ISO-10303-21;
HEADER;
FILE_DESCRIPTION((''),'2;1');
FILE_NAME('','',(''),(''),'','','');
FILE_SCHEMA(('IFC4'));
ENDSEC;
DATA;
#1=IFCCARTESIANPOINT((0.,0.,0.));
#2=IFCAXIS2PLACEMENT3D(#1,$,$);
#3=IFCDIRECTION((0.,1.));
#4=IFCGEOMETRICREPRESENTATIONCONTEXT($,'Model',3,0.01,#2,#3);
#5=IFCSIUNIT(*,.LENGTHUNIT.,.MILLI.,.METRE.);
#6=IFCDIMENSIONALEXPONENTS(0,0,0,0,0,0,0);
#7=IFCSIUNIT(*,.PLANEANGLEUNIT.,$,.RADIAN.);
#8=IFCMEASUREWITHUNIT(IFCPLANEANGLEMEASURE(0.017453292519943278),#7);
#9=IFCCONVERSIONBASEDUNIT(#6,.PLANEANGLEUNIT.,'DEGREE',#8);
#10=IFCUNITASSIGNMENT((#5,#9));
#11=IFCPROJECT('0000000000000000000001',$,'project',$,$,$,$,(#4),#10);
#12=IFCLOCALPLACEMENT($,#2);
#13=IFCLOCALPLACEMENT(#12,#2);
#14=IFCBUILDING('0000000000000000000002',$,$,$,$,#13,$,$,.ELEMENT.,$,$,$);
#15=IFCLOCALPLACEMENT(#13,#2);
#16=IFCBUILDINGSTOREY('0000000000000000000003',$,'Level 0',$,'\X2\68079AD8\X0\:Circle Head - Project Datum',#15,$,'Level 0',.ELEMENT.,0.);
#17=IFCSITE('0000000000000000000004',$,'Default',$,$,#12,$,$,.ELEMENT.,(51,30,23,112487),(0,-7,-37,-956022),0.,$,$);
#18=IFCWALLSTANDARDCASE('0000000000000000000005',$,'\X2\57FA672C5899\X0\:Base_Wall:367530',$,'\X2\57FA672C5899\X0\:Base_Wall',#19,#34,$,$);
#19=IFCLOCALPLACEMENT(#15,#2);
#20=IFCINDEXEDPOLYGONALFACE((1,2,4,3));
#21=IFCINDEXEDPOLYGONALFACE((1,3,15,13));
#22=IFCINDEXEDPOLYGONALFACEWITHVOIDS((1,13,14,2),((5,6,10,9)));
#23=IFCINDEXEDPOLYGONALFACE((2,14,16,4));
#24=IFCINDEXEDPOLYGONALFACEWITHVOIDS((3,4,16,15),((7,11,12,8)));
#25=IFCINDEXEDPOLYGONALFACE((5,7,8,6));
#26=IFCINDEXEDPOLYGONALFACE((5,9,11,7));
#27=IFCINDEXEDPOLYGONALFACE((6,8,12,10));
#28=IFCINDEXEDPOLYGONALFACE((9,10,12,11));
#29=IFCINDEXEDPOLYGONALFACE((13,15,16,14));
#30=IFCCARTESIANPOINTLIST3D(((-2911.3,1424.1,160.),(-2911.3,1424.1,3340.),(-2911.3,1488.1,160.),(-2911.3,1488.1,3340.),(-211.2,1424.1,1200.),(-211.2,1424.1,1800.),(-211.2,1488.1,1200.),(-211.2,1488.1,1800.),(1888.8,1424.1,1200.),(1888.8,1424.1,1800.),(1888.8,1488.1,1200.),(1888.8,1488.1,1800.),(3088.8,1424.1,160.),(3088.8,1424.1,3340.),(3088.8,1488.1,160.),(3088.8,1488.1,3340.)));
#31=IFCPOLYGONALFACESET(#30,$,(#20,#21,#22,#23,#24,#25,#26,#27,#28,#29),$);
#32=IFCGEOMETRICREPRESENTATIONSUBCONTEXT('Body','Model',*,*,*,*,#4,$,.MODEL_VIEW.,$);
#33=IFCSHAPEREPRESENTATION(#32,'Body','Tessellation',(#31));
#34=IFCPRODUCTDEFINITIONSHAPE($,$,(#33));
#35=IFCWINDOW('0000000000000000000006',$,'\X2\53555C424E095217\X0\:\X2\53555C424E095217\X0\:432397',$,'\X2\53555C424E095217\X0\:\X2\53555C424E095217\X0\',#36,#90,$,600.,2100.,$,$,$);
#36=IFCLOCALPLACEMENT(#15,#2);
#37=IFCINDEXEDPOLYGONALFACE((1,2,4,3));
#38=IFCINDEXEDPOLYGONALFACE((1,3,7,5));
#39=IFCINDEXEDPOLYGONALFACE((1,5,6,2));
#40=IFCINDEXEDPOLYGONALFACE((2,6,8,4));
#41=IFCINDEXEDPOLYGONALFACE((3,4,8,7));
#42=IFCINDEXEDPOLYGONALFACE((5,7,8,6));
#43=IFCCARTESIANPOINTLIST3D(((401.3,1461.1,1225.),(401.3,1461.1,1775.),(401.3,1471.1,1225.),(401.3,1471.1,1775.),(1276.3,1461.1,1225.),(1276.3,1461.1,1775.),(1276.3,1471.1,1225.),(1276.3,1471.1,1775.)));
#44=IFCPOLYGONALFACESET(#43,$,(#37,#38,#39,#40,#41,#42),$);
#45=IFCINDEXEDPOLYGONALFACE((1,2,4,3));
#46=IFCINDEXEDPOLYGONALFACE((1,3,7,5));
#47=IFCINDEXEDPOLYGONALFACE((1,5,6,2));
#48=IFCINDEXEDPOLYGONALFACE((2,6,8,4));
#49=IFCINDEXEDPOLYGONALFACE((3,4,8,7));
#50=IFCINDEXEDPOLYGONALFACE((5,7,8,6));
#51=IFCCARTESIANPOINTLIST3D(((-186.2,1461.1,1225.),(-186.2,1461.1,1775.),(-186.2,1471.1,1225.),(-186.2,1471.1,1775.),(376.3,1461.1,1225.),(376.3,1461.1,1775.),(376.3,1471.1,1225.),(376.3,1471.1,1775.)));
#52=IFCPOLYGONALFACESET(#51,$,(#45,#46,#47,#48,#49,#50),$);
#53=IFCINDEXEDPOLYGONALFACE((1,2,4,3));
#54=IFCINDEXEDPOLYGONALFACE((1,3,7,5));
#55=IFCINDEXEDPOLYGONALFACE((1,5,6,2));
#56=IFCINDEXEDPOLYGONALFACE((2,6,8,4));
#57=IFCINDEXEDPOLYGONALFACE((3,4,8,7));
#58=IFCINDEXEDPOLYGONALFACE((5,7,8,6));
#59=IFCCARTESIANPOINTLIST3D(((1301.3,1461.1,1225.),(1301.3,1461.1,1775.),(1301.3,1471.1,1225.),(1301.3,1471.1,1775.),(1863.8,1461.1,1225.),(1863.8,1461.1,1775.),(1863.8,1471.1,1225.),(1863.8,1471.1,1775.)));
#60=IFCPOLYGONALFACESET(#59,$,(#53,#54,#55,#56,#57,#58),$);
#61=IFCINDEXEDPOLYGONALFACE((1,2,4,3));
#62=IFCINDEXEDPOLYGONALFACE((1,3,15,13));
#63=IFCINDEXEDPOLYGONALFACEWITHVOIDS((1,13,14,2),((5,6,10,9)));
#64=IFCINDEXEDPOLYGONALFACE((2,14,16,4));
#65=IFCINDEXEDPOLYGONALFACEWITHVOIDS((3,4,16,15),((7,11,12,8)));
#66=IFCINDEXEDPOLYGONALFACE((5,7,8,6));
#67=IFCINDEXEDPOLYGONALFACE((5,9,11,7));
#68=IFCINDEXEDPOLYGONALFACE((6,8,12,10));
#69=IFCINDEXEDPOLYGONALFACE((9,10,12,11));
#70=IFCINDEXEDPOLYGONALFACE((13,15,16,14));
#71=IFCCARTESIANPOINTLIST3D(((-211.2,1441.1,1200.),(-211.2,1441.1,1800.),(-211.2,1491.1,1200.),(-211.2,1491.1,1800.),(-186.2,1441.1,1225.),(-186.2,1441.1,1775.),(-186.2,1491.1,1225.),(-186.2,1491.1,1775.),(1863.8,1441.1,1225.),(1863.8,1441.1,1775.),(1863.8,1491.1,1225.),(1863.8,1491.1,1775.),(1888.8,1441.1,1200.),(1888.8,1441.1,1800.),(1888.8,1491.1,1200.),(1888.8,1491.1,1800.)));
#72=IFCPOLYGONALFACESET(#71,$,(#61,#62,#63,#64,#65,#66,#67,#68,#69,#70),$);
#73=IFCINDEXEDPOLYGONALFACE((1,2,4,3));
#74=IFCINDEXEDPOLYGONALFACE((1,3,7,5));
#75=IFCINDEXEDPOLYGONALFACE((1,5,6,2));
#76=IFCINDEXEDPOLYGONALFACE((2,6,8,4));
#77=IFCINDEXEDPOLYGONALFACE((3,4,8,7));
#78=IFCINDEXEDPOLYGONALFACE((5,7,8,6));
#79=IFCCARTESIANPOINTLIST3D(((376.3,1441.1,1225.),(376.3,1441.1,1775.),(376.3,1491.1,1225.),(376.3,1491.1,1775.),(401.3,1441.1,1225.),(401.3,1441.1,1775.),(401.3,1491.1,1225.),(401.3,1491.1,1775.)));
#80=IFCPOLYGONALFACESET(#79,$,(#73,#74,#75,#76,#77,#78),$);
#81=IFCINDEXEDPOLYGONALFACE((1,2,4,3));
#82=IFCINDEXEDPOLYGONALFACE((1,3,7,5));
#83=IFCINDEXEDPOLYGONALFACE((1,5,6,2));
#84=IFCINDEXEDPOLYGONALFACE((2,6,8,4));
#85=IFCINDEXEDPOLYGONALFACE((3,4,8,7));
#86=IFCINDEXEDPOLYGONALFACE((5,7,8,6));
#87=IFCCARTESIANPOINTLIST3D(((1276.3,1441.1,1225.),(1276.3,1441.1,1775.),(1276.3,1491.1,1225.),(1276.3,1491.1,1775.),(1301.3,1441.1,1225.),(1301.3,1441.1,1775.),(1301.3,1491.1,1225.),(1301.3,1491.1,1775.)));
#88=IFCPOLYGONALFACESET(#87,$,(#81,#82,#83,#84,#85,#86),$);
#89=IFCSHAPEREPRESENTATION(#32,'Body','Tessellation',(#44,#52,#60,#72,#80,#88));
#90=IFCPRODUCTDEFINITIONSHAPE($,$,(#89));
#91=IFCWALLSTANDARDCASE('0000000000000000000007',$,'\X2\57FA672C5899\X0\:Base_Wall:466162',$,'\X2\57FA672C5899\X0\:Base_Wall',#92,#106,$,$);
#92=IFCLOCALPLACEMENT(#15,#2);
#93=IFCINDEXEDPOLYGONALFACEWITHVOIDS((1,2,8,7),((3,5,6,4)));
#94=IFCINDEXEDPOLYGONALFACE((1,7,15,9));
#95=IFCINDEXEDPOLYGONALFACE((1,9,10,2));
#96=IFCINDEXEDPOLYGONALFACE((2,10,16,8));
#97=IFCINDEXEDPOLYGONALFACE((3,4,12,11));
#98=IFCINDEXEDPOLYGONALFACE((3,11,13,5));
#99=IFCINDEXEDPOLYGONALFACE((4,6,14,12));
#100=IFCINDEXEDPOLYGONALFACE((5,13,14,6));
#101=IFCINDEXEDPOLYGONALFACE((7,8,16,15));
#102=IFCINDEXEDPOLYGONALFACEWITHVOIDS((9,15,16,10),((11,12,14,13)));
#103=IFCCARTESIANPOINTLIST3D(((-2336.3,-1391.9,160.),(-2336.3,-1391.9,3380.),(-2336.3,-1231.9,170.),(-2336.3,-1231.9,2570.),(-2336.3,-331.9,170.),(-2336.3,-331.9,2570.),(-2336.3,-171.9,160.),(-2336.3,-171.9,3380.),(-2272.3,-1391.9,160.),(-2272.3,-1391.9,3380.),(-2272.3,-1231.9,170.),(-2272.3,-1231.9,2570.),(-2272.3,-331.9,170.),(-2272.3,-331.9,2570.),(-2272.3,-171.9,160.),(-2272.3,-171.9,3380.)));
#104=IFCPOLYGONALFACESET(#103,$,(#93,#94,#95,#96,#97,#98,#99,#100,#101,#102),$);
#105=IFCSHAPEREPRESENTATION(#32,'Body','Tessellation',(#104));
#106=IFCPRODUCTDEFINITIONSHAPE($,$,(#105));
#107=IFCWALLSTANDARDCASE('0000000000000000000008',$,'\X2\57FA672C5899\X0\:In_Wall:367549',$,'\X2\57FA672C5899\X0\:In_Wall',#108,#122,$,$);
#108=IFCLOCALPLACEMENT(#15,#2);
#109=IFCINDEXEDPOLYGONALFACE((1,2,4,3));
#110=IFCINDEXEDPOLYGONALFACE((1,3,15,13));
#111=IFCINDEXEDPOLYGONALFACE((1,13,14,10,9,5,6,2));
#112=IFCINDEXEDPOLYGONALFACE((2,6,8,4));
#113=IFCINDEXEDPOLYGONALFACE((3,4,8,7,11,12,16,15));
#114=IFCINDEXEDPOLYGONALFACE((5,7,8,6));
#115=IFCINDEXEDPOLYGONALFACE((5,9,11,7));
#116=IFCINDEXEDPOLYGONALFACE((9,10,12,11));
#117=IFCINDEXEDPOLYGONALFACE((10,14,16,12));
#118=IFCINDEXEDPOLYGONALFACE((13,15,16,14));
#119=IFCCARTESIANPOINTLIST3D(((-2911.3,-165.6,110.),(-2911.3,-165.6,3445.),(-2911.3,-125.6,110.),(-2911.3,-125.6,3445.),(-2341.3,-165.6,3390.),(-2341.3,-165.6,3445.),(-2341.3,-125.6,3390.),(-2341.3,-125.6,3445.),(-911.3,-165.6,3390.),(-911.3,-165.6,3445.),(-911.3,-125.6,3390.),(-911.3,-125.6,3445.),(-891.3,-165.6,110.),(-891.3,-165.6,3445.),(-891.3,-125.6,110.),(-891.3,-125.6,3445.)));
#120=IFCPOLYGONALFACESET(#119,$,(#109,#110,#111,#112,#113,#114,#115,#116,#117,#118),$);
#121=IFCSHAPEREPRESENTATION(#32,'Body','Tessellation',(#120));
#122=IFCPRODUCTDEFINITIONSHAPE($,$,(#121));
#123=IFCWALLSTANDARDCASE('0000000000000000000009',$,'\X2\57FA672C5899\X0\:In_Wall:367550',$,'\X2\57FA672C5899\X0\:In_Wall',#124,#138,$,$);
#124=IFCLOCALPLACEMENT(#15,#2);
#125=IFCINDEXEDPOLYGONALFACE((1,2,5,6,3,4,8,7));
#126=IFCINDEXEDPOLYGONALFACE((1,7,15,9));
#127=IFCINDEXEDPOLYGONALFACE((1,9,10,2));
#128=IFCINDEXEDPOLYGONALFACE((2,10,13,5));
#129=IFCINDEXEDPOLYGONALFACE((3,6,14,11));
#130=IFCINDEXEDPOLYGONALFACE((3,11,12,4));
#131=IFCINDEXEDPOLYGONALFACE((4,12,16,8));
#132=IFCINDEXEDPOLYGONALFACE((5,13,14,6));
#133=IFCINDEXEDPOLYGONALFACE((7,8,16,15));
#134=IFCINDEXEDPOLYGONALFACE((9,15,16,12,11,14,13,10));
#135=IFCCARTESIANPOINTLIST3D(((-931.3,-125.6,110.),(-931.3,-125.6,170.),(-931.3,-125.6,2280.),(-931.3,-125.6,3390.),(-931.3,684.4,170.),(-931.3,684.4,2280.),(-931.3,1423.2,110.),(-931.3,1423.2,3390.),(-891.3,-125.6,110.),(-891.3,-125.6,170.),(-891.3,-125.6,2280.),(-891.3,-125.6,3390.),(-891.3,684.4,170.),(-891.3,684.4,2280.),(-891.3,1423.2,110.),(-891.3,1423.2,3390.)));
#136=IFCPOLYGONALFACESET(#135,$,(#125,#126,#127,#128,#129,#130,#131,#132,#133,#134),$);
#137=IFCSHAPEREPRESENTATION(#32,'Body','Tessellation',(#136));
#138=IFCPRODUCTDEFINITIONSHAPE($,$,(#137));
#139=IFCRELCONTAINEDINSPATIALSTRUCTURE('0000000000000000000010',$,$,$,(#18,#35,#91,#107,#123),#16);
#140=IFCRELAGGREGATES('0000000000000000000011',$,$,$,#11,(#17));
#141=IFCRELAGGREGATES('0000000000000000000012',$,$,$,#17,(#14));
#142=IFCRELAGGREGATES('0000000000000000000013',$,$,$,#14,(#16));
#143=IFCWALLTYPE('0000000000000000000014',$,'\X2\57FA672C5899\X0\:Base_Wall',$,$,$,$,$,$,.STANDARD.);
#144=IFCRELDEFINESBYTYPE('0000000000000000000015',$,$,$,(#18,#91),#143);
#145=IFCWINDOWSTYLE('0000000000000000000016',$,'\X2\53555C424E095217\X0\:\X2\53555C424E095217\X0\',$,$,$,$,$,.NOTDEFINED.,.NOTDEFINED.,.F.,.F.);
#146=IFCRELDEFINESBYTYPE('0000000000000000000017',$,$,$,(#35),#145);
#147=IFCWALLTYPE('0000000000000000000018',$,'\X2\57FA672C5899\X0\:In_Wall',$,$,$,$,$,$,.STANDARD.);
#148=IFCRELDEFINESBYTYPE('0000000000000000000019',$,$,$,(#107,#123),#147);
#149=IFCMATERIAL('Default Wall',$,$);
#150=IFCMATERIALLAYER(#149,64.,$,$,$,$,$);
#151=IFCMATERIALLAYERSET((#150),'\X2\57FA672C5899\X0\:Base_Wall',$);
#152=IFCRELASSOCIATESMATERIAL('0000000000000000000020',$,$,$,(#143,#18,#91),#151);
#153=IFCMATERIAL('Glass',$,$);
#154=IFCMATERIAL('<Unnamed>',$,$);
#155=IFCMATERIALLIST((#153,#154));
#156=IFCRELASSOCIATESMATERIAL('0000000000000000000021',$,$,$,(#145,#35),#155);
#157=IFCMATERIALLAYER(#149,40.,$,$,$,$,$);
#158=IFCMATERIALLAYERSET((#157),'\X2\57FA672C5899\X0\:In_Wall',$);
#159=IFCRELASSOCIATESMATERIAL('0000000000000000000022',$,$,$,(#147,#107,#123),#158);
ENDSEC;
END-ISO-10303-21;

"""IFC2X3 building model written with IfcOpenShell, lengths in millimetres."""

from ifc_helpers import new_model, entity, si_unit, converted_unit, direction, frame, frame_2d, origin, origin_2d_with_axis, place, context, subcontext, project, spatial, polyline, rectangle, outline, extrude, source, transform, mapped, material, material_list, layer, layer_set, layer_usage, type_object, type_shapes, element, fill, save


model = new_model("IFC2X3")

# Units and contexts
model_context = context("Model", 3, precision=0.01, world=origin(), true_north=direction((0.0, 1.0)))
body_context = subcontext(model_context, "Body", "Model", "MODEL_VIEW")
ifc_project = project(units=[si_unit("LENGTHUNIT", "METRE", prefix="MILLI"), converted_unit("PLANEANGLEUNIT", "DEGREE", entity("IfcPlaneAngleMeasure", 0.017453292519943278), si_unit("PLANEANGLEUNIT", "RADIAN"), dimensions=[0, 0, 0, 0, 0, 0, 0])], contexts=[model_context])

# Site, building, storey
site_placement = place(None, origin())
site = spatial("IfcSite", under=ifc_project, at=site_placement, Name="Default", CompositionType="ELEMENT", RefLatitude=(51, 30, 23, 112487), RefLongitude=(0, -7, -37, -956022), RefElevation=0.0)
building_placement = place(site_placement, origin())
building = spatial("IfcBuilding", under=site, at=building_placement, CompositionType="ELEMENT")
storey_placement = place(building_placement, origin())
storey = spatial("IfcBuildingStorey", under=building, at=storey_placement, Name="Level 0", ObjectType="标高:Circle Head - Project Datum", LongName="Level 0", CompositionType="ELEMENT", Elevation=0.0)

# Shared definitions
ifc_material_1 = material(Name="Default Wall")
ifc_layer_1 = layer(ifc_material_1, 64.0)
ifc_layer_set_1 = layer_set([ifc_layer_1], Name="基本墙:Base_Wall")
wall_type_1 = type_object("IfcWallType", Name="基本墙:Base_Wall", PredefinedType="STANDARD", material=ifc_layer_set_1)

# Wall, opening, window
ifc_layer_usage_1 = layer_usage(ifc_layer_set_1, "AXIS2", "POSITIVE", -32.0)
wall_1_placement = place(storey_placement, frame((-2911.3, 1456.1, 160.0)))
wall_1 = element("IfcWallStandardCase", 1, at=wall_1_placement, inside=storey, type_object=wall_type_1, material=ifc_layer_usage_1, Name="基本墙:Base_Wall:367530", ObjectType="基本墙:Base_Wall", context=body_context, shape_type="SweptSolid", body=[
    extrude(rectangle(XDim=6000.1, YDim=64.0, at=frame_2d((3000.1, 0.0), x_axis=(-1.0, 0.0))), origin(), (0.0, 0.0, 1.0), 3180.0),
])
opening_1_placement = place(wall_1_placement, frame((2700.1, -32.0, 1040.0)))
opening_1 = element("IfcOpeningElement", 2, at=opening_1_placement, cuts=wall_1, ObjectType="Opening", context=body_context, shape_type="SweptSolid", body=[
    extrude(rectangle(XDim=600.0, YDim=2100.0, at=frame_2d((300.0, 1050.0), x_axis=(1.0, 0.0))), frame((0.0, 0.0, 0.0), z_axis=(0.0, 1.0, 0.0), x_axis=(0.0, 0.0, 1.0)), (0.0, 0.0, 1.0), 64.0),
])
ifc_material_2 = material(Name="Glass")
ifc_material_3 = material(Name="<Unnamed>")
ifc_material_list = material_list([ifc_material_2, ifc_material_3])
window_style = type_object("IfcWindowStyle", Name="单层三列:单层三列", ConstructionType="NOTDEFINED", OperationType="NOTDEFINED", ParameterTakesPrecedence=False, Sizeable=False, material=ifc_material_list)
shared_shape_1 = source(origin(), body_context, "Body", "SweptSolid", [
    extrude(rectangle(XDim=10.0, YDim=875.0, at=origin_2d_with_axis()), frame((1050.0, 42.0, 25.0), z_axis=(0.0, 0.0, 1.0), x_axis=(0.0, 1.0, 0.0)), (0.0, 0.0, 1.0), 550.0),
    extrude(rectangle(XDim=10.0, YDim=562.5, at=frame_2d((0.0, 0.0), x_axis=(1.0, 0.0))), frame((306.3, 42.0, 25.0), z_axis=(0.0, 0.0, 1.0), x_axis=(0.0, 1.0, 0.0)), (0.0, 0.0, 1.0), 550.0),
    extrude(rectangle(XDim=10.0, YDim=562.5, at=frame_2d((0.0, 0.0), x_axis=(1.0, 0.0))), frame((1793.8, 42.0, 25.0), z_axis=(0.0, 0.0, 1.0), x_axis=(0.0, 1.0, 0.0)), (0.0, 0.0, 1.0), 550.0),
    extrude(outline(polyline([(-1050.0, -300.0), (1050.0, -300.0), (1050.0, 300.0), (-1050.0, 300.0), (-1050.0, -300.0)]), holes=[polyline([(1025.0, -275.0), (-1025.0, -275.0), (-1025.0, 275.0), (1025.0, 275.0), (1025.0, -275.0)])]), frame((1050.0, 17.0, 300.0), z_axis=(0.0, 1.0, 0.0), x_axis=(1.0, 0.0, 0.0)), (0.0, 0.0, 1.0), 50.0),
    extrude(rectangle(XDim=50.0, YDim=25.0, at=origin_2d_with_axis()), frame((600.0, 42.0, 25.0), z_axis=(0.0, 0.0, 1.0), x_axis=(0.0, -1.0, 0.0)), (0.0, 0.0, 1.0), 550.0),
    extrude(rectangle(XDim=50.0, YDim=25.0, at=frame_2d((0.0, 0.0), x_axis=(1.0, 0.0))), frame((1500.0, 42.0, 25.0), z_axis=(0.0, 0.0, 1.0), x_axis=(0.0, -1.0, 0.0)), (0.0, 0.0, 1.0), 550.0),
])
type_shapes(window_style, [shared_shape_1])
window_placement = place(opening_1_placement, origin())
window = element("IfcWindow", 3, at=window_placement, inside=storey, type_object=window_style, material=ifc_material_list, Name="单层三列:单层三列:432397", ObjectType="单层三列:单层三列", OverallHeight=600.0, OverallWidth=2100.0, context=body_context, shape_type="MappedRepresentation", body=[
    mapped(shared_shape_1, transform((0.0, 0.0, 0.0), scale=1.0)),
])
fill(opening_1, window)

# Walls, openings
ifc_layer_usage_2 = layer_usage(ifc_layer_set_1, "AXIS2", "NEGATIVE", 32.0)
wall_2_placement = place(storey_placement, frame((-2304.3, -1391.9, 160.0), z_axis=(0.0, 0.0, 1.0), x_axis=(0.0, 1.0, 0.0)))
wall_2 = element("IfcWallStandardCase", 4, at=wall_2_placement, inside=storey, type_object=wall_type_1, material=ifc_layer_usage_2, Name="基本墙:Base_Wall:466162", ObjectType="基本墙:Base_Wall", context=body_context, shape_type="SweptSolid", body=[
    extrude(rectangle(XDim=1220.0, YDim=64.0, at=frame_2d((610.0, 0.0), x_axis=(-1.0, 0.0))), origin(), (0.0, 0.0, 1.0), 3220.0),
])
opening_2_placement = place(wall_2_placement, frame((160.0, -32.0, 10.0)))
element("IfcOpeningElement", 5, at=opening_2_placement, cuts=wall_2, ObjectType="Opening", context=body_context, shape_type="SweptSolid", body=[
    extrude(rectangle(XDim=2400.0, YDim=900.0, at=frame_2d((1200.0, 450.0), x_axis=(1.0, 0.0))), frame((0.0, 0.0, 0.0), z_axis=(0.0, 1.0, 0.0), x_axis=(0.0, 0.0, 1.0)), (0.0, 0.0, 1.0), 64.0),
])
ifc_layer_2 = layer(ifc_material_1, 40.0)
ifc_layer_set_2 = layer_set([ifc_layer_2], Name="基本墙:In_Wall")
ifc_layer_usage_3 = layer_usage(ifc_layer_set_2, "AXIS2", "NEGATIVE", 20.0)
wall_type_2 = type_object("IfcWallType", Name="基本墙:In_Wall", PredefinedType="STANDARD", material=ifc_layer_set_2)
wall_3_placement = place(storey_placement, frame((-2911.3, -145.6, 110.0)))
wall_3 = element("IfcWallStandardCase", 6, at=wall_3_placement, inside=storey, type_object=wall_type_2, material=ifc_layer_usage_3, Name="基本墙:In_Wall:367549", ObjectType="基本墙:In_Wall", context=body_context, shape_type="SweptSolid", body=[
    extrude(rectangle(XDim=2020.0, YDim=40.0, at=frame_2d((1010.0, 0.0), x_axis=(-1.0, 0.0))), origin(), (0.0, 0.0, 1.0), 3335.0),
])
opening_3_placement = place(wall_3_placement, origin())
element("IfcOpeningElement", 7, at=opening_3_placement, cuts=wall_3, ObjectType="Opening", context=body_context, shape_type="SweptSolid", body=[
    extrude(rectangle(XDim=55.0, YDim=1430.0, at=frame_2d((0.0, 0.0), x_axis=(1.0, 0.0))), frame((1285.0, 20.0, 3307.5), z_axis=(0.0, -1.0, 0.0), x_axis=(0.0, 0.0, 1.0)), (0.0, 0.0, 1.0), 40.0),
])
ifc_layer_usage_4 = layer_usage(ifc_layer_set_2, "AXIS2", "NEGATIVE", 20.0)
wall_4_placement = place(storey_placement, frame((-911.3, 1423.2, 110.0), z_axis=(0.0, 0.0, 1.0), x_axis=(0.0, -1.0, 0.0)))
wall_4 = element("IfcWallStandardCase", 8, at=wall_4_placement, inside=storey, type_object=wall_type_2, material=ifc_layer_usage_4, Name="基本墙:In_Wall:367550", ObjectType="基本墙:In_Wall", context=body_context, shape_type="SweptSolid", body=[
    extrude(rectangle(XDim=1548.9, YDim=40.0, at=frame_2d((774.4, 0.0), x_axis=(-1.0, 0.0))), origin(), (0.0, 0.0, 1.0), 3280.0),
])
opening_4_placement = place(wall_4_placement, frame((1548.9, 20.0, 60.0)))
element("IfcOpeningElement", 9, at=opening_4_placement, cuts=wall_4, ObjectType="Opening", context=body_context, shape_type="SweptSolid", body=[
    extrude(rectangle(XDim=2110.0, YDim=810.0, at=frame_2d((1055.0, 405.0), x_axis=(1.0, 0.0))), frame((0.0, 0.0, 0.0), z_axis=(0.0, -1.0, 0.0), x_axis=(0.0, 0.0, 1.0)), (0.0, 0.0, 1.0), 40.0),
])

save(model, "model.ifc")
